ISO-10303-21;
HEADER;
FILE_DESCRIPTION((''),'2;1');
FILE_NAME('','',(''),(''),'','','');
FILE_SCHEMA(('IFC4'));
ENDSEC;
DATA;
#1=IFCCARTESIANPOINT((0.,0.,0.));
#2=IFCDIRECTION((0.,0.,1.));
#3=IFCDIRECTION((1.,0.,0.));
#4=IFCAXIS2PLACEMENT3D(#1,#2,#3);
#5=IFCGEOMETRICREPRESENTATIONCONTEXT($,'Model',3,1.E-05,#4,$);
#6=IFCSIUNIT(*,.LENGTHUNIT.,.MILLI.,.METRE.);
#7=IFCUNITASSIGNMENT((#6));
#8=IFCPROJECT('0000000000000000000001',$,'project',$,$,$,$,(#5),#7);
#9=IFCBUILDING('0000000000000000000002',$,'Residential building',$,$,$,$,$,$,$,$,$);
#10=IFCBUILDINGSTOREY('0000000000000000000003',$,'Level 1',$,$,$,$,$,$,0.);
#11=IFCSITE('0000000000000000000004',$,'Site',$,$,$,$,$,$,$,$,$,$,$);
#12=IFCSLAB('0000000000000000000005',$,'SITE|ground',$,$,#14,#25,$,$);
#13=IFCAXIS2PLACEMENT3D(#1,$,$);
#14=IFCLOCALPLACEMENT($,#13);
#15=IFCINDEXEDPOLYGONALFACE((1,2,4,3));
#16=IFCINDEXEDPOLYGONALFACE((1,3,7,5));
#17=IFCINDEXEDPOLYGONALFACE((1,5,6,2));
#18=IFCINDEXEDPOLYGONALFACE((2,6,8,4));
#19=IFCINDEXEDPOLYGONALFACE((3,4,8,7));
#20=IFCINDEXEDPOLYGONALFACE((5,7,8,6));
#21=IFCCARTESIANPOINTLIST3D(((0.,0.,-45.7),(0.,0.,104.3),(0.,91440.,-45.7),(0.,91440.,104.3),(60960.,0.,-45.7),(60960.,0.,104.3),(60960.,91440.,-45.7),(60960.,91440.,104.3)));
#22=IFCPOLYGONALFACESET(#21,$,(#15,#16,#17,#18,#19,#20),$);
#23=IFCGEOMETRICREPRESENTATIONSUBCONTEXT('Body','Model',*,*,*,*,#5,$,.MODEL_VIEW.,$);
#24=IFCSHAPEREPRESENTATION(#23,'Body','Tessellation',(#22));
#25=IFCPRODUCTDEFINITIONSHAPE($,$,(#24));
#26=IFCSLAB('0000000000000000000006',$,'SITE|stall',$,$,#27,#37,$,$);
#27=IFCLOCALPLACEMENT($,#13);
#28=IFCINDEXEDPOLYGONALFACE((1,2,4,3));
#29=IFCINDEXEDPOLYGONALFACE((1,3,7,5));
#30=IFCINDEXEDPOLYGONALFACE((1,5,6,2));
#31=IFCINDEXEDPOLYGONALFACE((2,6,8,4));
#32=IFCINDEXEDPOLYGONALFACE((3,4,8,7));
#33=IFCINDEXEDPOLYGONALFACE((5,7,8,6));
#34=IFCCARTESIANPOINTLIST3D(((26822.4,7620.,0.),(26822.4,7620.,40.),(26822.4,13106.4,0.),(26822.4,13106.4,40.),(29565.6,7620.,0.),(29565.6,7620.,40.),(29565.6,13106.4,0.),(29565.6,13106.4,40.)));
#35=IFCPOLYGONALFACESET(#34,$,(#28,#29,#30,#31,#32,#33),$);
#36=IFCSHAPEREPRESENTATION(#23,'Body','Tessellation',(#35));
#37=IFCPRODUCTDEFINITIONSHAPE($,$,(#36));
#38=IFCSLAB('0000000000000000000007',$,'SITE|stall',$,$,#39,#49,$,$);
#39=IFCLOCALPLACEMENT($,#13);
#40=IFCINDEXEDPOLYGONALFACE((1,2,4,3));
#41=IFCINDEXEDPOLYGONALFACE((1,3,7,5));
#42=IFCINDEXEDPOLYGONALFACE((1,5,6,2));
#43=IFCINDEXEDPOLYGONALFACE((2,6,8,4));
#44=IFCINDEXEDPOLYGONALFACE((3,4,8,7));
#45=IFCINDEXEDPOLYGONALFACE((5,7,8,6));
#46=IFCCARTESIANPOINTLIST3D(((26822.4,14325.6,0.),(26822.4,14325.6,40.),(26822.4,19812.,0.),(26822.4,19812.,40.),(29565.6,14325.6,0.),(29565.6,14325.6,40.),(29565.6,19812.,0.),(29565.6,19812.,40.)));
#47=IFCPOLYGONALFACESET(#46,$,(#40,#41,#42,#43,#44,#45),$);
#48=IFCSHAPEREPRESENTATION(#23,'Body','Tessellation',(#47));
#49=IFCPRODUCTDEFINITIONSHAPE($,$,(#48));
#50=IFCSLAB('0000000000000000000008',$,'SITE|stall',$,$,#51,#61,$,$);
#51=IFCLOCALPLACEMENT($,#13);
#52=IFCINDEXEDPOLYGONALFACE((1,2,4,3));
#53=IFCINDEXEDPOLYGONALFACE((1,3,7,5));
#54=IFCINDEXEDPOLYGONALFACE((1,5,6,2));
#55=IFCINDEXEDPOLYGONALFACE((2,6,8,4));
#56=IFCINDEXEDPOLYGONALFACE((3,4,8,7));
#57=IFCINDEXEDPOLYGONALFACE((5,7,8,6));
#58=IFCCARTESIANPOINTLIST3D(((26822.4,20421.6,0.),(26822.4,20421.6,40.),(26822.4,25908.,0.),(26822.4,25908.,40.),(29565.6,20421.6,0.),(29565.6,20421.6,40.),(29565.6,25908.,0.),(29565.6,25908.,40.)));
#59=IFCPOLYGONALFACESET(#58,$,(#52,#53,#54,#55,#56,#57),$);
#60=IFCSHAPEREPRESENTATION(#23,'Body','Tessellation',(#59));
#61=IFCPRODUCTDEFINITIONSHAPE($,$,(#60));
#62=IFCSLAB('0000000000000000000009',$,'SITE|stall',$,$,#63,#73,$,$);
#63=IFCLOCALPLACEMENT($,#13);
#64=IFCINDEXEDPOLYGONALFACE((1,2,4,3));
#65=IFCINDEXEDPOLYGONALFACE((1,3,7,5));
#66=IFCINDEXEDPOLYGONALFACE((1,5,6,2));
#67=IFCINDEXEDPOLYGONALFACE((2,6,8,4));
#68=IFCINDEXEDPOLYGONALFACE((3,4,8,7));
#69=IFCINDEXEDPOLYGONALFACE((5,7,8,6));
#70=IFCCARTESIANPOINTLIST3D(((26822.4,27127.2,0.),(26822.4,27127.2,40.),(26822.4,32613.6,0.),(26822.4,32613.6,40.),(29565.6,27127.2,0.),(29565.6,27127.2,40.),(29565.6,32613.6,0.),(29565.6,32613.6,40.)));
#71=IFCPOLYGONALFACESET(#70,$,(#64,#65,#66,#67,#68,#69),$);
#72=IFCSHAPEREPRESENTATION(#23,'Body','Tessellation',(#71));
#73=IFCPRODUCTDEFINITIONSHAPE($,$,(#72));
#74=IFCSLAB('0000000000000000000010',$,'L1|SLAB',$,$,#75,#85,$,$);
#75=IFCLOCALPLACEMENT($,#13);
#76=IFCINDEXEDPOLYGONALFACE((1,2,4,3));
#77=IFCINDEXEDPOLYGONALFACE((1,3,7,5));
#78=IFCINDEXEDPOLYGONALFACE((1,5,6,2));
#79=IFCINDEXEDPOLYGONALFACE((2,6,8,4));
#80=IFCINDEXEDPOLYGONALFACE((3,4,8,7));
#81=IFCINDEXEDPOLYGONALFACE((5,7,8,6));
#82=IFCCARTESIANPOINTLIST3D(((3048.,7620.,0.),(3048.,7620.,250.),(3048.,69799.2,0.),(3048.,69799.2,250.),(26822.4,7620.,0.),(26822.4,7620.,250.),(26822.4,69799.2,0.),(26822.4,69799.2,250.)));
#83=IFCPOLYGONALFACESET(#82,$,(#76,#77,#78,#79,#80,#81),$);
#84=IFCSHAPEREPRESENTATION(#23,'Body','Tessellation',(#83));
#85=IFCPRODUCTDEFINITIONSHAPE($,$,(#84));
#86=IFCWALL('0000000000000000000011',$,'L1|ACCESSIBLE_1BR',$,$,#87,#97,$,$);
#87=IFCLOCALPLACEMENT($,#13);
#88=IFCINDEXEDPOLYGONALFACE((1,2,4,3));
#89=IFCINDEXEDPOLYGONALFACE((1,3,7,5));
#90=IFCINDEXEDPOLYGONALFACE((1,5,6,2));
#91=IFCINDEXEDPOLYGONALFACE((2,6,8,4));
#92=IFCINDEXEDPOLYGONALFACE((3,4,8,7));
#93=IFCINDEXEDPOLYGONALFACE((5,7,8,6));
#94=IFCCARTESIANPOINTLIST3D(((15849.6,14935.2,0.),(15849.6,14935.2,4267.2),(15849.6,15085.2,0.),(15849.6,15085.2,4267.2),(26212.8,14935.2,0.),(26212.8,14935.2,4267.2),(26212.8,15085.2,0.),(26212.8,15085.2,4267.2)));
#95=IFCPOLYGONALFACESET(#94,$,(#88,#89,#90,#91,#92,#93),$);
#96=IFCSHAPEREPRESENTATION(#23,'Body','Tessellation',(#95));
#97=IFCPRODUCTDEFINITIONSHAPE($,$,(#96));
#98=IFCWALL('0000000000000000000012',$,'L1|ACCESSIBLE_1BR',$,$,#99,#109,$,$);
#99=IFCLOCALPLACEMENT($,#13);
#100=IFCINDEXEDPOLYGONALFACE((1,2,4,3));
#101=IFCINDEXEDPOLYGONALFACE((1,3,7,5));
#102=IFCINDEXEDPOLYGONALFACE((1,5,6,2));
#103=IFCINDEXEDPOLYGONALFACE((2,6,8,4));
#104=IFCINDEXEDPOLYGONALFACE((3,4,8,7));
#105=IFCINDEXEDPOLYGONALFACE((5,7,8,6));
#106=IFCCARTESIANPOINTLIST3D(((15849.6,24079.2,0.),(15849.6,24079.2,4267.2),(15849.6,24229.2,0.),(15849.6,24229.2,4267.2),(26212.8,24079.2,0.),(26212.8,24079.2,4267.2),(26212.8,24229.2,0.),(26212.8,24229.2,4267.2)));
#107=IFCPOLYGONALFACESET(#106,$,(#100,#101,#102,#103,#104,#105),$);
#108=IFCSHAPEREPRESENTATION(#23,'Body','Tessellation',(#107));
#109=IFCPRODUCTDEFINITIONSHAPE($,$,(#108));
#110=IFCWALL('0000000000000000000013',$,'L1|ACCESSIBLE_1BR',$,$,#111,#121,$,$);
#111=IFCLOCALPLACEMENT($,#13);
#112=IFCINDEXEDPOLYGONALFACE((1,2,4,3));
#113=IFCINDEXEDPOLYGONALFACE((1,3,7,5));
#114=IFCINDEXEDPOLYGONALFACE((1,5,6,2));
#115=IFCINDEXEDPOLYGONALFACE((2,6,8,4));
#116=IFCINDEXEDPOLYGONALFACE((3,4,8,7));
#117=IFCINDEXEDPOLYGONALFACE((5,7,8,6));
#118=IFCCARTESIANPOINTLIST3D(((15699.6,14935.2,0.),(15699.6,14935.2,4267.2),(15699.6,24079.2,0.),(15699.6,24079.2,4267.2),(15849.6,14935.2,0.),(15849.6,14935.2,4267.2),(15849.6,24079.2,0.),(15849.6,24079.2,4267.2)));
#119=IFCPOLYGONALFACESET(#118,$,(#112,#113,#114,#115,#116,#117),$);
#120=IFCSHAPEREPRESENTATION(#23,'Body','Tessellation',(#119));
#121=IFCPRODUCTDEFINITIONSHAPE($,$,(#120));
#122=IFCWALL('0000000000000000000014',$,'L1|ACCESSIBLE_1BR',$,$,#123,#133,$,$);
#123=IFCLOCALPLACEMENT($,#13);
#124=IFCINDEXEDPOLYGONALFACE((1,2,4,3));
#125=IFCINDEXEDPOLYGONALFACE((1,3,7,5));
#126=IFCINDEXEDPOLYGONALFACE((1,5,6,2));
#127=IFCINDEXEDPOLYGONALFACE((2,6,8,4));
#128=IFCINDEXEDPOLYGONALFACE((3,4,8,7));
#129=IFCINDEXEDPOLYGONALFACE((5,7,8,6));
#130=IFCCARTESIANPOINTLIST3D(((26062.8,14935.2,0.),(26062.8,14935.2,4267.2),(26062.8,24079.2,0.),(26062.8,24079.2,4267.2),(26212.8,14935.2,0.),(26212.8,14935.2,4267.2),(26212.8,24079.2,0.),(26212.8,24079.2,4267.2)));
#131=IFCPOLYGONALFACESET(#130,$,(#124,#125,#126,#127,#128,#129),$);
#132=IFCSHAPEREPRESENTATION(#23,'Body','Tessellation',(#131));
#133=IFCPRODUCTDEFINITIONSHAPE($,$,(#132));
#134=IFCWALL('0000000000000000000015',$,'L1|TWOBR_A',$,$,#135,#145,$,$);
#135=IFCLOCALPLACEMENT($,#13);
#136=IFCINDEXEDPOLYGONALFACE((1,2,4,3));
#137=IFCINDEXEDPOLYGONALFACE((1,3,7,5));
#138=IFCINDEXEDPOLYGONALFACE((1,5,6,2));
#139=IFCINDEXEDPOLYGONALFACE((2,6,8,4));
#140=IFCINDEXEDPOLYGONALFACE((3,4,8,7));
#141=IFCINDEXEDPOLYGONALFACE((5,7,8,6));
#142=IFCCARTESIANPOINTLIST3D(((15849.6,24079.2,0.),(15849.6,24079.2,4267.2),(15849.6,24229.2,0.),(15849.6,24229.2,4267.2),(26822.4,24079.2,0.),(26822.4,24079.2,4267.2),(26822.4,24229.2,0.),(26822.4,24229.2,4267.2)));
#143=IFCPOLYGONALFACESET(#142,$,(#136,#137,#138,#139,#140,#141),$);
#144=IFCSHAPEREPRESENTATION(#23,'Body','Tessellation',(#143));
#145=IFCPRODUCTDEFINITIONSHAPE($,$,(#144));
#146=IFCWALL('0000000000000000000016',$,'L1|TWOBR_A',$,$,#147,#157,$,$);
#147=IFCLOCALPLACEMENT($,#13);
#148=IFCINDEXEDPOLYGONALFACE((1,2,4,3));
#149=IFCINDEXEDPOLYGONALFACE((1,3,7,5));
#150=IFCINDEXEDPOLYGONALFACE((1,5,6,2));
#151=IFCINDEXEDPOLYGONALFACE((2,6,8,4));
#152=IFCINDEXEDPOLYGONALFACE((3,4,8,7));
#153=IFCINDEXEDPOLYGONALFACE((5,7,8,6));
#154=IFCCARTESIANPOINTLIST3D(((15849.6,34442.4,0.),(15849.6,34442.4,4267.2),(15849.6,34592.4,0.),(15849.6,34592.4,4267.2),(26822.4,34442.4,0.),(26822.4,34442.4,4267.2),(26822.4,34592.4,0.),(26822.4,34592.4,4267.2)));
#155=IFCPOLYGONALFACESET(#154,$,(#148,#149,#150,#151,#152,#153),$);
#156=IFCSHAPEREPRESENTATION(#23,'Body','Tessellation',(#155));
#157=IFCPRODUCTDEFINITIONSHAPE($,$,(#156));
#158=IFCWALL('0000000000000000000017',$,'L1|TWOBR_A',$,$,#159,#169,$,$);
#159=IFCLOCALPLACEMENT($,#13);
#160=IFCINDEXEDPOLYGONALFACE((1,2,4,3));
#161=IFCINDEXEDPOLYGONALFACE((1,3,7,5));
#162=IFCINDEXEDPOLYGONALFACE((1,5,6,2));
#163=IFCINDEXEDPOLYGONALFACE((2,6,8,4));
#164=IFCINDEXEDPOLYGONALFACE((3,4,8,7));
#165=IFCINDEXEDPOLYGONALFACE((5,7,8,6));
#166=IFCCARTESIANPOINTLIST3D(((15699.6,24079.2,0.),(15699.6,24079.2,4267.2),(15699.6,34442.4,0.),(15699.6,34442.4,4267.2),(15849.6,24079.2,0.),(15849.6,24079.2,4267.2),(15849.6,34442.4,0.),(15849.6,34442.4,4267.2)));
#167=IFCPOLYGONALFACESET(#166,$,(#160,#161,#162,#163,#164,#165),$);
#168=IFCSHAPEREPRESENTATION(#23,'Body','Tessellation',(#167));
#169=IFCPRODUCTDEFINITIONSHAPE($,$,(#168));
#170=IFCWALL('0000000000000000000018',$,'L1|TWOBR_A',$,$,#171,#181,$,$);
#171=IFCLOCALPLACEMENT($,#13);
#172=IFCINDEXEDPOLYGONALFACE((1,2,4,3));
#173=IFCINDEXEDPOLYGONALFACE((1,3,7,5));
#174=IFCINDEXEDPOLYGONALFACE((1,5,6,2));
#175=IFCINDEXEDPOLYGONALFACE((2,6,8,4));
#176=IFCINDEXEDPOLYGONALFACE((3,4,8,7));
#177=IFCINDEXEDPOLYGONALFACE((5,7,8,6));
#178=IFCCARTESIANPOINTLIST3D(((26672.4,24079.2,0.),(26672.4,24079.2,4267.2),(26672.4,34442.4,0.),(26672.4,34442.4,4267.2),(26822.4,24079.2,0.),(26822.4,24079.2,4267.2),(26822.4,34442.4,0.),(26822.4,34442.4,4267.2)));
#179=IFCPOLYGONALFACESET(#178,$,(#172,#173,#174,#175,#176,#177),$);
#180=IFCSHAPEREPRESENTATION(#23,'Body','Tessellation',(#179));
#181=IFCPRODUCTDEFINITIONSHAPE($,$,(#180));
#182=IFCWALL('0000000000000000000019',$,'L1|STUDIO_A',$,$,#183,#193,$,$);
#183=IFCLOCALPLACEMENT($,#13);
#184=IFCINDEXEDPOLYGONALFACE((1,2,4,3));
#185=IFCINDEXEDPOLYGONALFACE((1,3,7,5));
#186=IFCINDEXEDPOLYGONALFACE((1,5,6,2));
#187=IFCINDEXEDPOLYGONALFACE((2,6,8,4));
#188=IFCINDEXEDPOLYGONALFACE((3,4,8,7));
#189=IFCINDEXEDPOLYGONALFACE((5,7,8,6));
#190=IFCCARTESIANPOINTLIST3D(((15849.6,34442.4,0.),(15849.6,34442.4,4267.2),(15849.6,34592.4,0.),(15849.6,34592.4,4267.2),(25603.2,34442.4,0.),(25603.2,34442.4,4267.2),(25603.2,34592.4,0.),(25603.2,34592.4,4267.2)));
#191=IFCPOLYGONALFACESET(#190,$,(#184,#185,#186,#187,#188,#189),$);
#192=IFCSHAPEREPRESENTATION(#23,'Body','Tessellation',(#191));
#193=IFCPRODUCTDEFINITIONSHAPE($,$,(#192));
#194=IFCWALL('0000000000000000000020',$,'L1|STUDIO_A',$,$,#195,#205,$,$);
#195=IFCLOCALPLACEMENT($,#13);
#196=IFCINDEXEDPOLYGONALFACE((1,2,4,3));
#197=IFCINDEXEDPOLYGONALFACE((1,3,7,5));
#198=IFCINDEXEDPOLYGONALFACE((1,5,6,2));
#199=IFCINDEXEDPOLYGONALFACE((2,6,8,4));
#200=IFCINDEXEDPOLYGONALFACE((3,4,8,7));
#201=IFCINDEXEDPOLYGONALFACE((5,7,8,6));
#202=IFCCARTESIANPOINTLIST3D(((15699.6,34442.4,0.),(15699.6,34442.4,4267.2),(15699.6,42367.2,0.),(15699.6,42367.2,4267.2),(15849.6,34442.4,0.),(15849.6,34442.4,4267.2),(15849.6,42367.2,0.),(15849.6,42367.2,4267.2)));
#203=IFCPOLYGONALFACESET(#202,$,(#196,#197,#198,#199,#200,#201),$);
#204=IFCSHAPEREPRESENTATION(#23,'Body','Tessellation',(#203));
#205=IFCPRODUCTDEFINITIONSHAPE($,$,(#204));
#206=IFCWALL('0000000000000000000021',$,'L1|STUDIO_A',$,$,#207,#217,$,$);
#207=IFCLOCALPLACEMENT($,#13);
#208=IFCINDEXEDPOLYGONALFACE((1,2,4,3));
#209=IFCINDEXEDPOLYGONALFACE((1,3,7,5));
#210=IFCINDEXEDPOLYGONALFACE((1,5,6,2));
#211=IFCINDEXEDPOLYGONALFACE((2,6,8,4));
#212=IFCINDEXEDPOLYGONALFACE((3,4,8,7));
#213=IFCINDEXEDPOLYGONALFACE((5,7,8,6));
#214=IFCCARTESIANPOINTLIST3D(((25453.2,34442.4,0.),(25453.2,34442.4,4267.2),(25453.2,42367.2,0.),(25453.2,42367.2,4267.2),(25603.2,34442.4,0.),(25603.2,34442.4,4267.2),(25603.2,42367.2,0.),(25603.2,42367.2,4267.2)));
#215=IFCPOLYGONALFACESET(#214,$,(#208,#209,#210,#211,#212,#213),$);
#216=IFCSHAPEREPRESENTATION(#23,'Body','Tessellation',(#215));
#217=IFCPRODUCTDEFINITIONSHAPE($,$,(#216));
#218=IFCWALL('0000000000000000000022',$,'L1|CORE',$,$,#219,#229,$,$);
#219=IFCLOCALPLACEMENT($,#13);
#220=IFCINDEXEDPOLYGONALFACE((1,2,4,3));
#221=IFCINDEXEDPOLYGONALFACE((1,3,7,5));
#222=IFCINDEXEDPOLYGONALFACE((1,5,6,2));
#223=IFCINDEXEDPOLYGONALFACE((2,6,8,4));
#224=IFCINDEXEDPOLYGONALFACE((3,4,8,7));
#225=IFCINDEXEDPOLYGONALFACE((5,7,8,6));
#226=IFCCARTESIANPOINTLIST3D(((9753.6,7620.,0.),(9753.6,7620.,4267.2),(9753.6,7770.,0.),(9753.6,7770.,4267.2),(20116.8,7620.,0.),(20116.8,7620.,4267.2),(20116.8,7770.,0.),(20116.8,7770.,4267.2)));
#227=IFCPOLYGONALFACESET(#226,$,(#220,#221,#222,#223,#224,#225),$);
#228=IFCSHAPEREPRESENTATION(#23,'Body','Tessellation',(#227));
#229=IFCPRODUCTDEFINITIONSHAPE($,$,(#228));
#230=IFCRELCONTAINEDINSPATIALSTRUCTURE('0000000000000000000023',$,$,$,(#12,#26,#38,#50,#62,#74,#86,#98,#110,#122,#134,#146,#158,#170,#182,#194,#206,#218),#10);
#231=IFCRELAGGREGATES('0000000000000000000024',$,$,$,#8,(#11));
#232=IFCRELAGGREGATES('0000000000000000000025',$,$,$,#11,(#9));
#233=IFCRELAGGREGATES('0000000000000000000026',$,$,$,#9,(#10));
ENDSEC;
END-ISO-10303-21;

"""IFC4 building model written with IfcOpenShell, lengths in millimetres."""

from ifc_helpers import new_model, si_unit, frame, origin_with_axes, place, context, subcontext, project, spatial, indexed_curve, outline, extrude, element, save


model = new_model("IFC4")

# Units and contexts
model_context = context("Model", 3, precision=1e-05, world=origin_with_axes())
body_context = subcontext(model_context, "Body", "Model", "MODEL_VIEW")
ifc_project = project(units=[si_unit("LENGTHUNIT", "METRE", prefix="MILLI")], contexts=[model_context])

# Site, building, storey
site = spatial("IfcSite", under=ifc_project, Name="Site")
building = spatial("IfcBuilding", under=site, Name="Residential building")
storey = spatial("IfcBuildingStorey", under=building, Name="Level 1", Elevation=0.0)

# Slabs
slab_1_placement = place(None, frame((0.0, 0.0, -45.7), z_axis=(0.0, 0.0, 1.0), x_axis=(1.0, 0.0, 0.0)))
element("IfcSlab", 1, at=slab_1_placement, inside=storey, Name="SITE|ground", context=body_context, shape_type="SweptSolid", body=[
    extrude(outline(indexed_curve([(0.0, 0.0), (60960.0, 0.0), (60960.0, 91440.0), (0.0, 91440.0), (0.0, 0.0)])), None, (0.0, 0.0, 1.0), 150.0),
])
for number, where, z_axis, x_axis, name in (
    (2, (26822.4, 7620.0, 0.0), (0.0, 0.0, 1.0), (1.0, 0.0, 0.0), "SITE|stall"),
    (3, (26822.4, 14325.6, 0.0), (0.0, 0.0, 1.0), (1.0, 0.0, 0.0), "SITE|stall"),
    (4, (26822.4, 20421.6, 0.0), (0.0, 0.0, 1.0), (1.0, 0.0, 0.0), "SITE|stall"),
    (5, (26822.4, 27127.2, 0.0), (0.0, 0.0, 1.0), (1.0, 0.0, 0.0), "SITE|stall"),
):
    element("IfcSlab", number, at=place(None, frame(where, z_axis=z_axis, x_axis=x_axis)), inside=storey, Name=name, context=body_context, shape_type="SweptSolid", body=[
        extrude(outline(indexed_curve([(0.0, 0.0), (2743.2, 0.0), (2743.2, 5486.4), (0.0, 5486.4), (0.0, 0.0)])), None, (0.0, 0.0, 1.0), 40.0),
    ])
slab_2_placement = place(None, frame((3048.0, 7620.0, 0.0), z_axis=(0.0, 0.0, 1.0), x_axis=(1.0, 0.0, 0.0)))
element("IfcSlab", 6, at=slab_2_placement, inside=storey, Name="L1|SLAB", context=body_context, shape_type="SweptSolid", body=[
    extrude(outline(indexed_curve([(0.0, 0.0), (23774.4, 0.0), (23774.4, 62179.2), (0.0, 62179.2), (0.0, 0.0)])), None, (0.0, 0.0, 1.0), 250.0),
])

# Walls
for number, where, z_axis, x_axis, name in (
    (7, (15849.6, 14935.2, 0.0), (0.0, 0.0, 1.0), (1.0, 0.0, 0.0), "L1|ACCESSIBLE_1BR"),
    (8, (15849.6, 24079.2, 0.0), (0.0, 0.0, 1.0), (1.0, 0.0, 0.0), "L1|ACCESSIBLE_1BR"),
):
    element("IfcWall", number, at=place(None, frame(where, z_axis=z_axis, x_axis=x_axis)), inside=storey, Name=name, context=body_context, shape_type="SweptSolid", body=[
        extrude(outline(indexed_curve([(0.0, 0.0), (0.0, 150.0), (10363.2, 150.0), (10363.2, 0.0), (0.0, 0.0)], self_intersect=False)), origin_with_axes(), (0.0, 0.0, 1.0), 4267.2),
    ])
for number, where, z_axis, x_axis, name in (
    (9, (15849.6, 14935.2, 0.0), (0.0, 0.0, 1.0), (0.0, 1.0, 0.0), "L1|ACCESSIBLE_1BR"),
    (10, (26212.8, 14935.2, 0.0), (0.0, 0.0, 1.0), (0.0, 1.0, 0.0), "L1|ACCESSIBLE_1BR"),
):
    element("IfcWall", number, at=place(None, frame(where, z_axis=z_axis, x_axis=x_axis)), inside=storey, Name=name, context=body_context, shape_type="SweptSolid", body=[
        extrude(outline(indexed_curve([(0.0, 0.0), (0.0, 150.0), (9144.0, 150.0), (9144.0, 0.0), (0.0, 0.0)], self_intersect=False)), origin_with_axes(), (0.0, 0.0, 1.0), 4267.2),
    ])
for number, where, z_axis, x_axis, name in (
    (11, (15849.6, 24079.2, 0.0), (0.0, 0.0, 1.0), (1.0, 0.0, 0.0), "L1|TWOBR_A"),
    (12, (15849.6, 34442.4, 0.0), (0.0, 0.0, 1.0), (1.0, 0.0, 0.0), "L1|TWOBR_A"),
):
    element("IfcWall", number, at=place(None, frame(where, z_axis=z_axis, x_axis=x_axis)), inside=storey, Name=name, context=body_context, shape_type="SweptSolid", body=[
        extrude(outline(indexed_curve([(0.0, 0.0), (0.0, 150.0), (10972.8, 150.0), (10972.8, 0.0), (0.0, 0.0)], self_intersect=False)), origin_with_axes(), (0.0, 0.0, 1.0), 4267.2),
    ])
for number, where, z_axis, x_axis, name in (
    (13, (15849.6, 24079.2, 0.0), (0.0, 0.0, 1.0), (0.0, 1.0, 0.0), "L1|TWOBR_A"),
    (14, (26822.4, 24079.2, 0.0), (0.0, 0.0, 1.0), (0.0, 1.0, 0.0), "L1|TWOBR_A"),
):
    element("IfcWall", number, at=place(None, frame(where, z_axis=z_axis, x_axis=x_axis)), inside=storey, Name=name, context=body_context, shape_type="SweptSolid", body=[
        extrude(outline(indexed_curve([(0.0, 0.0), (0.0, 150.0), (10363.2, 150.0), (10363.2, 0.0), (0.0, 0.0)], self_intersect=False)), origin_with_axes(), (0.0, 0.0, 1.0), 4267.2),
    ])
wall_1_placement = place(None, frame((15849.6, 34442.4, 0.0), z_axis=(0.0, 0.0, 1.0), x_axis=(1.0, 0.0, 0.0)))
element("IfcWall", 15, at=wall_1_placement, inside=storey, Name="L1|STUDIO_A", context=body_context, shape_type="SweptSolid", body=[
    extrude(outline(indexed_curve([(0.0, 0.0), (0.0, 150.0), (9753.6, 150.0), (9753.6, 0.0), (0.0, 0.0)], self_intersect=False)), origin_with_axes(), (0.0, 0.0, 1.0), 4267.2),
])
for number, where, z_axis, x_axis, name in (
    (16, (15849.6, 34442.4, 0.0), (0.0, 0.0, 1.0), (0.0, 1.0, 0.0), "L1|STUDIO_A"),
    (17, (25603.2, 34442.4, 0.0), (0.0, 0.0, 1.0), (0.0, 1.0, 0.0), "L1|STUDIO_A"),
):
    element("IfcWall", number, at=place(None, frame(where, z_axis=z_axis, x_axis=x_axis)), inside=storey, Name=name, context=body_context, shape_type="SweptSolid", body=[
        extrude(outline(indexed_curve([(0.0, 0.0), (0.0, 150.0), (7924.8, 150.0), (7924.8, 0.0), (0.0, 0.0)], self_intersect=False)), origin_with_axes(), (0.0, 0.0, 1.0), 4267.2),
    ])
for number, where, z_axis, x_axis, name in (
    (18, (9753.6, 7620.0, 0.0), (0.0, 0.0, 1.0), (1.0, 0.0, 0.0), "L1|CORE"),
):
    element("IfcWall", number, at=place(None, frame(where, z_axis=z_axis, x_axis=x_axis)), inside=storey, Name=name, context=body_context, shape_type="SweptSolid", body=[
        extrude(outline(indexed_curve([(0.0, 0.0), (0.0, 150.0), (10363.2, 150.0), (10363.2, 0.0), (0.0, 0.0)], self_intersect=False)), origin_with_axes(), (0.0, 0.0, 1.0), 4267.2),
    ])

save(model, "model.ifc")
